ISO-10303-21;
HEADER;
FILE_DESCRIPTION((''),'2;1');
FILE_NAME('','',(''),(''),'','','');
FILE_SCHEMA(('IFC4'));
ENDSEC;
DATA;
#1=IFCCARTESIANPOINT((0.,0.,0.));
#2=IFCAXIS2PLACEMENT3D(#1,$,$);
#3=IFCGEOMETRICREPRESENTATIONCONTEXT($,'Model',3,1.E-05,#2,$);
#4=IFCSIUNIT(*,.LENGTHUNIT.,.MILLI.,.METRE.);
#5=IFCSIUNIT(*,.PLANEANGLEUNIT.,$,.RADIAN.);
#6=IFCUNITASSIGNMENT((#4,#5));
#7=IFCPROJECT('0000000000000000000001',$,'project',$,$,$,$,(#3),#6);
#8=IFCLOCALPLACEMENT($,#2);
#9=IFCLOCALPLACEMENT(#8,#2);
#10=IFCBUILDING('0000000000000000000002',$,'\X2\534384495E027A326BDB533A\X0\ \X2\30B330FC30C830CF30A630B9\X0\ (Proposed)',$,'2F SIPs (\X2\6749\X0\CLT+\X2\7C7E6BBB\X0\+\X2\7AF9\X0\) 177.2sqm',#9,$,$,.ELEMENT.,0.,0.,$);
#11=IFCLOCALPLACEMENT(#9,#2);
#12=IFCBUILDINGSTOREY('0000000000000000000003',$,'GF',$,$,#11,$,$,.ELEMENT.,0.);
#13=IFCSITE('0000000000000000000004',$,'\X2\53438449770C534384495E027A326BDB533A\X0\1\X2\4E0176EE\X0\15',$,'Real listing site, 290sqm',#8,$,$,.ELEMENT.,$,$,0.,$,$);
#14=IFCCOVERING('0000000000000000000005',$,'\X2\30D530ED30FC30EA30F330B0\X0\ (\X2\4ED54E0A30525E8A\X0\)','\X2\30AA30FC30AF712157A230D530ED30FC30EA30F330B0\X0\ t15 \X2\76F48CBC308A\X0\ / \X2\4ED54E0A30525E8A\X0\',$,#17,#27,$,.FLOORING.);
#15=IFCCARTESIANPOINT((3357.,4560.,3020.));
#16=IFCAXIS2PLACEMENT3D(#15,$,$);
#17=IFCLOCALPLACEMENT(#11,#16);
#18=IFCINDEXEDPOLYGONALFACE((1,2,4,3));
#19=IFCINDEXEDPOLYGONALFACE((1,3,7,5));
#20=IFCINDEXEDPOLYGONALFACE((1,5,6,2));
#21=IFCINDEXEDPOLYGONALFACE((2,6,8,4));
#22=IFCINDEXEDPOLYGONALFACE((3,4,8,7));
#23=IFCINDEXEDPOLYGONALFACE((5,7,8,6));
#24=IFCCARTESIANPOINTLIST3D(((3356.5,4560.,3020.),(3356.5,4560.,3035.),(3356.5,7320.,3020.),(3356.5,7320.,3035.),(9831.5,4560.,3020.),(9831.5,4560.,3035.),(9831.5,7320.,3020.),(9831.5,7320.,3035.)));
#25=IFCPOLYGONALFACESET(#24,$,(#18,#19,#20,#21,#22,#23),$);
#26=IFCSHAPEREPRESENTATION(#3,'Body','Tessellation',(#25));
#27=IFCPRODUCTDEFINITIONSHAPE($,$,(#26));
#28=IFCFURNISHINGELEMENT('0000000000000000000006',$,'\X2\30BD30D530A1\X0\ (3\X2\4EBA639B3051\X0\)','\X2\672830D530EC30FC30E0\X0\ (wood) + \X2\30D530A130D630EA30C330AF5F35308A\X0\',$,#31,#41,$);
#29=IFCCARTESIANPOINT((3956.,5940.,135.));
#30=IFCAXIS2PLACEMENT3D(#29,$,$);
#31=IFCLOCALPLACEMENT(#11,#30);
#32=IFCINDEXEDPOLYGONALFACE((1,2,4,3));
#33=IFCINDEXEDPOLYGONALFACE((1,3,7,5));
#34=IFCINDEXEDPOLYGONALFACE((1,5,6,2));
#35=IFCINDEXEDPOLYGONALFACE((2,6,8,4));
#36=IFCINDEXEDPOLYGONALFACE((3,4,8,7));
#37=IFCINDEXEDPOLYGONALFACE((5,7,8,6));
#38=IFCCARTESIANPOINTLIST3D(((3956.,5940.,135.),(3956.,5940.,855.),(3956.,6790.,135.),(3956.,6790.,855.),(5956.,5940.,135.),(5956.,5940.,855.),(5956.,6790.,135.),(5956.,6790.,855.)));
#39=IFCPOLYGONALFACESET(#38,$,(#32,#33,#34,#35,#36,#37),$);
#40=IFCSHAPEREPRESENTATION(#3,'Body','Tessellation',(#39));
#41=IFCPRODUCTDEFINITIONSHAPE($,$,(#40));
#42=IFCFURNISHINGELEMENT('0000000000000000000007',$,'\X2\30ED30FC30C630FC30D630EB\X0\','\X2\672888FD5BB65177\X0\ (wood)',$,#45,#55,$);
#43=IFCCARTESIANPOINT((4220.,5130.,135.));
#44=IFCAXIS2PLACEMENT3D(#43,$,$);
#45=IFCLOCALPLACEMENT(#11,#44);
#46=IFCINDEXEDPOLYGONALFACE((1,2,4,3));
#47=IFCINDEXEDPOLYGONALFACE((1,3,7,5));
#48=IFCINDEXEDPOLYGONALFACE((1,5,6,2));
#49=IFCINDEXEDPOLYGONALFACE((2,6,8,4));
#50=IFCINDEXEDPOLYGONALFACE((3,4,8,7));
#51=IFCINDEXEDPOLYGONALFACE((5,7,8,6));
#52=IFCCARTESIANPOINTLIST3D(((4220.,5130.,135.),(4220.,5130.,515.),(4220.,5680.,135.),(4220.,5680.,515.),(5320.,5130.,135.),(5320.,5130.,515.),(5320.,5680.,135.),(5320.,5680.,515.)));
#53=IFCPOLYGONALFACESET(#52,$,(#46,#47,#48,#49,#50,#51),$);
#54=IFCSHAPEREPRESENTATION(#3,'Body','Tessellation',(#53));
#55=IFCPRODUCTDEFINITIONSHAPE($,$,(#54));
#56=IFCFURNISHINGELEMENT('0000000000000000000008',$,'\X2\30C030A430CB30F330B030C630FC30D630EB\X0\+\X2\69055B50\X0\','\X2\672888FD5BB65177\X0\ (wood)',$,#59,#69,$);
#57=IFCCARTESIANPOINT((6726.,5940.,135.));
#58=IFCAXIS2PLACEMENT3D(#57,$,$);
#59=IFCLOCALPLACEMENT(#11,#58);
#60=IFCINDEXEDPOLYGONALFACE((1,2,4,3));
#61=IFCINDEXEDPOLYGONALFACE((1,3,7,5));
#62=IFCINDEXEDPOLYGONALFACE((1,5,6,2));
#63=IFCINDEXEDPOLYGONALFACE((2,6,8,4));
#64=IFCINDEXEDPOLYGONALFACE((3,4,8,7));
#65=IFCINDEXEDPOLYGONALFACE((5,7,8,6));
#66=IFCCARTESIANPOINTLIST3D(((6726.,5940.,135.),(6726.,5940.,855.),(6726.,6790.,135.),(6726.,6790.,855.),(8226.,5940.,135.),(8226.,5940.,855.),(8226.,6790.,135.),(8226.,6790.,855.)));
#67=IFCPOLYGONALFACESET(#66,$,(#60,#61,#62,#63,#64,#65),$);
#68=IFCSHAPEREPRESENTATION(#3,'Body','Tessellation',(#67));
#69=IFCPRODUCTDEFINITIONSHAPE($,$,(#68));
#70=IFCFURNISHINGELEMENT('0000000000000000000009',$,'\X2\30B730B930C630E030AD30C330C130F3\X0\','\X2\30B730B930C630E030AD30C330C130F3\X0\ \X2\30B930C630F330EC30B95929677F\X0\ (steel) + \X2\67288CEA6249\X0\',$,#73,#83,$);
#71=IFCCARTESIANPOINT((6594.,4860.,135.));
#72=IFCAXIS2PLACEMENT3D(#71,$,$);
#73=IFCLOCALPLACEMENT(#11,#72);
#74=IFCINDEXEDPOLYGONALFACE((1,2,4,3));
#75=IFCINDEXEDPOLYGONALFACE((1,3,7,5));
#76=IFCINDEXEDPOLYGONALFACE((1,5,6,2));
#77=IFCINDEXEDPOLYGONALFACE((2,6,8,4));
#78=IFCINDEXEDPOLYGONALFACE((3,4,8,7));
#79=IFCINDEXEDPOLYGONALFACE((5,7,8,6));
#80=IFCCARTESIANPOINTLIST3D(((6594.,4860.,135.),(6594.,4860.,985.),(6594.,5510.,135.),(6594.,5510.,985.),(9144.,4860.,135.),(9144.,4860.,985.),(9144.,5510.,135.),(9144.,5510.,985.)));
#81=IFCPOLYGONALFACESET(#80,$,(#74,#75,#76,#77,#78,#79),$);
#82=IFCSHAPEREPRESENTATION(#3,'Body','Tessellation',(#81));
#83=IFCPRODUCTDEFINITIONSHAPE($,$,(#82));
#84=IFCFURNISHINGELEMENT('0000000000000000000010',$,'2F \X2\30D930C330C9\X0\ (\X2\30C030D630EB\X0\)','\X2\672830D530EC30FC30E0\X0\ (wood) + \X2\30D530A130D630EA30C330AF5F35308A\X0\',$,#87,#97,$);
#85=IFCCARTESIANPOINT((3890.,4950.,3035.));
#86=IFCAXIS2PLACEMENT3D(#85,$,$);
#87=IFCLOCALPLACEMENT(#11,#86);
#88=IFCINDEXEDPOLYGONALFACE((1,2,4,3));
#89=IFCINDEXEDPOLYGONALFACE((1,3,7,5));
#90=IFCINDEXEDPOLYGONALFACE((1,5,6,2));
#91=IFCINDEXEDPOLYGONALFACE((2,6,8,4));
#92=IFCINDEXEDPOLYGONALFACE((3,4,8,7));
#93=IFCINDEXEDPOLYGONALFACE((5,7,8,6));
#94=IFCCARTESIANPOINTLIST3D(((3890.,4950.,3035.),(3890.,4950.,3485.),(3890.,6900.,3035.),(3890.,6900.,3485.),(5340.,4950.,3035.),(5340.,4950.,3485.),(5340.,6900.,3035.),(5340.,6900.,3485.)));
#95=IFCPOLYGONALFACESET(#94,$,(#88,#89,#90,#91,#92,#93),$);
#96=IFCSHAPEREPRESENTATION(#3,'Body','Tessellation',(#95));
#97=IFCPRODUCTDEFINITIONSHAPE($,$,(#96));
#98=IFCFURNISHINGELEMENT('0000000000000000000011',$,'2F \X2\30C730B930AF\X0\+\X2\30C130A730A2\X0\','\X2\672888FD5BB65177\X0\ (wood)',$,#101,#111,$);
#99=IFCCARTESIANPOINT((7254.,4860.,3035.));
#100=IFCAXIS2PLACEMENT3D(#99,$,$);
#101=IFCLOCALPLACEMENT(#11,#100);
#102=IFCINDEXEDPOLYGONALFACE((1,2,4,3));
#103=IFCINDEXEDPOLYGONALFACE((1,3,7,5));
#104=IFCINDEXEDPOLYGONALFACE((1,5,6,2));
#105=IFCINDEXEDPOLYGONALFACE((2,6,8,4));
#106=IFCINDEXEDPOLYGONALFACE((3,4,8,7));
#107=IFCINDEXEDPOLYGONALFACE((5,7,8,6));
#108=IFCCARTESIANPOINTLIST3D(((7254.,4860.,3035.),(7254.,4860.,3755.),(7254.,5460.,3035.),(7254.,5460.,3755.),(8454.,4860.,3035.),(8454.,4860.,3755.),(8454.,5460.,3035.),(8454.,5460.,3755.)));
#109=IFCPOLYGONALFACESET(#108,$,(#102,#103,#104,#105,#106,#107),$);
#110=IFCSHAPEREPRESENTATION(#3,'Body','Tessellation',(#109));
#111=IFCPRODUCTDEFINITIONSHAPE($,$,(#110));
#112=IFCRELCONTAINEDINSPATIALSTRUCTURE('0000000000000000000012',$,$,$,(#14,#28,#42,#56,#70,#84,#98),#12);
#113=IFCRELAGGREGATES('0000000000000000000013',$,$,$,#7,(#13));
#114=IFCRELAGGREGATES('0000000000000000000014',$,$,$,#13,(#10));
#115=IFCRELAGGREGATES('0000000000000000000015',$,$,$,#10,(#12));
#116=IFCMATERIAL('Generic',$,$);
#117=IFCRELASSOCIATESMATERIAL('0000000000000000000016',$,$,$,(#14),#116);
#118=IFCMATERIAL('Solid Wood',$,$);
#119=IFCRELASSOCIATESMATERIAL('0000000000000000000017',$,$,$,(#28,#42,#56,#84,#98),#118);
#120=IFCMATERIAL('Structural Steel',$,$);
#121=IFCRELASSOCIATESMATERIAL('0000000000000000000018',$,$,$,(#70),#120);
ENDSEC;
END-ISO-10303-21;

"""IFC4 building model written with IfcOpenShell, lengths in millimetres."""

from ifc_helpers import new_model, si_unit, frame, frame_2d, origin, place, context, project, spatial, rectangle, extrude, material, element, save


model = new_model("IFC4")

# Units and contexts
model_context = context("Model", 3, precision=1e-05, world=origin())
ifc_project = project(units=[si_unit("LENGTHUNIT", "METRE", prefix="MILLI"), si_unit("PLANEANGLEUNIT", "RADIAN")], contexts=[model_context])

# Site, building, storey
site_placement = place(None, origin())
site = spatial("IfcSite", under=ifc_project, at=site_placement, Name="千葉県千葉市稲毛区1丁目15", ObjectType="Real listing site, 290sqm", CompositionType="ELEMENT", RefElevation=0.0)
building_placement = place(site_placement, origin())
building = spatial("IfcBuilding", under=site, at=building_placement, Name="千葉市稲毛区 コートハウス (Proposed)", ObjectType="2F SIPs (杉CLT+籾殻+竹) 177.2sqm", CompositionType="ELEMENT", ElevationOfRefHeight=0.0, ElevationOfTerrain=0.0)
storey_placement = place(building_placement, origin())
storey = spatial("IfcBuildingStorey", under=building, at=storey_placement, Name="GF", CompositionType="ELEMENT", Elevation=0.0)

# Shared definitions
ifc_material_1 = material(Name="Solid Wood")

# Shared definitions
ifc_material_2 = material(Name="Generic")

# Shared definitions
ifc_material_3 = material(Name="Structural Steel")

# Covering
covering_placement = place(storey_placement, frame((3357.0, 4560.0, 3020.0)))
element("IfcCovering", 1, at=covering_placement, inside=storey, material=ifc_material_2, Name="フローリング (仕上げ床)", Description="オーク無垢フローリング t15 直貼り / 仕上げ床", PredefinedType="FLOORING", context=model_context, shape_type="SweptSolid", body=[
    extrude(rectangle(XDim=6475.0, YDim=2760.0, at=frame_2d((3237.0, 1380.0))), frame((3357.0, 4560.0, 3020.0)), (0.0, 0.0, 1.0), 15.0),
])

# Furnishing elements
furnishing_1_placement = place(storey_placement, frame((3956.0, 5940.0, 135.0)))
element("IfcFurnishingElement", 2, at=furnishing_1_placement, inside=storey, material=ifc_material_1, Name="ソファ (3人掛け)", Description="木フレーム (wood) + ファブリック張り", context=model_context, shape_type="SweptSolid", body=[
    extrude(rectangle(XDim=2000.0, YDim=850.0, at=frame_2d((1000.0, 425.0))), frame((3956.0, 5940.0, 135.0)), (0.0, 0.0, 1.0), 720.0),
])
furnishing_2_placement = place(storey_placement, frame((4220.0, 5130.0, 135.0)))
element("IfcFurnishingElement", 3, at=furnishing_2_placement, inside=storey, material=ifc_material_1, Name="ローテーブル", Description="木製家具 (wood)", context=model_context, shape_type="SweptSolid", body=[
    extrude(rectangle(XDim=1100.0, YDim=550.0, at=frame_2d((550.0, 275.0))), frame((4220.0, 5130.0, 135.0)), (0.0, 0.0, 1.0), 380.0),
])
furnishing_3_placement = place(storey_placement, frame((6726.0, 5940.0, 135.0)))
element("IfcFurnishingElement", 4, at=furnishing_3_placement, inside=storey, material=ifc_material_1, Name="ダイニングテーブル+椅子", Description="木製家具 (wood)", context=model_context, shape_type="SweptSolid", body=[
    extrude(rectangle(XDim=1500.0, YDim=850.0, at=frame_2d((750.0, 425.0))), frame((6726.0, 5940.0, 135.0)), (0.0, 0.0, 1.0), 720.0),
])
furnishing_4_placement = place(storey_placement, frame((6594.0, 4860.0, 135.0)))
element("IfcFurnishingElement", 5, at=furnishing_4_placement, inside=storey, material=ifc_material_3, Name="システムキッチン", Description="システムキッチン ステンレス天板 (steel) + 木質扉", context=model_context, shape_type="SweptSolid", body=[
    extrude(rectangle(XDim=2550.0, YDim=650.0, at=frame_2d((1275.0, 325.0))), frame((6594.0, 4860.0, 135.0)), (0.0, 0.0, 1.0), 850.0),
])
furnishing_5_placement = place(storey_placement, frame((3890.0, 4950.0, 3035.0)))
element("IfcFurnishingElement", 6, at=furnishing_5_placement, inside=storey, material=ifc_material_1, Name="2F ベッド (ダブル)", Description="木フレーム (wood) + ファブリック張り", context=model_context, shape_type="SweptSolid", body=[
    extrude(rectangle(XDim=1450.0, YDim=1950.0, at=frame_2d((725.0, 975.0))), frame((3890.0, 4950.0, 3035.0)), (0.0, 0.0, 1.0), 450.0),
])
furnishing_6_placement = place(storey_placement, frame((7254.0, 4860.0, 3035.0)))
element("IfcFurnishingElement", 7, at=furnishing_6_placement, inside=storey, material=ifc_material_1, Name="2F デスク+チェア", Description="木製家具 (wood)", context=model_context, shape_type="SweptSolid", body=[
    extrude(rectangle(XDim=1200.0, YDim=600.0, at=frame_2d((600.0, 300.0))), frame((7254.0, 4860.0, 3035.0)), (0.0, 0.0, 1.0), 720.0),
])

save(model, "model.ifc")
